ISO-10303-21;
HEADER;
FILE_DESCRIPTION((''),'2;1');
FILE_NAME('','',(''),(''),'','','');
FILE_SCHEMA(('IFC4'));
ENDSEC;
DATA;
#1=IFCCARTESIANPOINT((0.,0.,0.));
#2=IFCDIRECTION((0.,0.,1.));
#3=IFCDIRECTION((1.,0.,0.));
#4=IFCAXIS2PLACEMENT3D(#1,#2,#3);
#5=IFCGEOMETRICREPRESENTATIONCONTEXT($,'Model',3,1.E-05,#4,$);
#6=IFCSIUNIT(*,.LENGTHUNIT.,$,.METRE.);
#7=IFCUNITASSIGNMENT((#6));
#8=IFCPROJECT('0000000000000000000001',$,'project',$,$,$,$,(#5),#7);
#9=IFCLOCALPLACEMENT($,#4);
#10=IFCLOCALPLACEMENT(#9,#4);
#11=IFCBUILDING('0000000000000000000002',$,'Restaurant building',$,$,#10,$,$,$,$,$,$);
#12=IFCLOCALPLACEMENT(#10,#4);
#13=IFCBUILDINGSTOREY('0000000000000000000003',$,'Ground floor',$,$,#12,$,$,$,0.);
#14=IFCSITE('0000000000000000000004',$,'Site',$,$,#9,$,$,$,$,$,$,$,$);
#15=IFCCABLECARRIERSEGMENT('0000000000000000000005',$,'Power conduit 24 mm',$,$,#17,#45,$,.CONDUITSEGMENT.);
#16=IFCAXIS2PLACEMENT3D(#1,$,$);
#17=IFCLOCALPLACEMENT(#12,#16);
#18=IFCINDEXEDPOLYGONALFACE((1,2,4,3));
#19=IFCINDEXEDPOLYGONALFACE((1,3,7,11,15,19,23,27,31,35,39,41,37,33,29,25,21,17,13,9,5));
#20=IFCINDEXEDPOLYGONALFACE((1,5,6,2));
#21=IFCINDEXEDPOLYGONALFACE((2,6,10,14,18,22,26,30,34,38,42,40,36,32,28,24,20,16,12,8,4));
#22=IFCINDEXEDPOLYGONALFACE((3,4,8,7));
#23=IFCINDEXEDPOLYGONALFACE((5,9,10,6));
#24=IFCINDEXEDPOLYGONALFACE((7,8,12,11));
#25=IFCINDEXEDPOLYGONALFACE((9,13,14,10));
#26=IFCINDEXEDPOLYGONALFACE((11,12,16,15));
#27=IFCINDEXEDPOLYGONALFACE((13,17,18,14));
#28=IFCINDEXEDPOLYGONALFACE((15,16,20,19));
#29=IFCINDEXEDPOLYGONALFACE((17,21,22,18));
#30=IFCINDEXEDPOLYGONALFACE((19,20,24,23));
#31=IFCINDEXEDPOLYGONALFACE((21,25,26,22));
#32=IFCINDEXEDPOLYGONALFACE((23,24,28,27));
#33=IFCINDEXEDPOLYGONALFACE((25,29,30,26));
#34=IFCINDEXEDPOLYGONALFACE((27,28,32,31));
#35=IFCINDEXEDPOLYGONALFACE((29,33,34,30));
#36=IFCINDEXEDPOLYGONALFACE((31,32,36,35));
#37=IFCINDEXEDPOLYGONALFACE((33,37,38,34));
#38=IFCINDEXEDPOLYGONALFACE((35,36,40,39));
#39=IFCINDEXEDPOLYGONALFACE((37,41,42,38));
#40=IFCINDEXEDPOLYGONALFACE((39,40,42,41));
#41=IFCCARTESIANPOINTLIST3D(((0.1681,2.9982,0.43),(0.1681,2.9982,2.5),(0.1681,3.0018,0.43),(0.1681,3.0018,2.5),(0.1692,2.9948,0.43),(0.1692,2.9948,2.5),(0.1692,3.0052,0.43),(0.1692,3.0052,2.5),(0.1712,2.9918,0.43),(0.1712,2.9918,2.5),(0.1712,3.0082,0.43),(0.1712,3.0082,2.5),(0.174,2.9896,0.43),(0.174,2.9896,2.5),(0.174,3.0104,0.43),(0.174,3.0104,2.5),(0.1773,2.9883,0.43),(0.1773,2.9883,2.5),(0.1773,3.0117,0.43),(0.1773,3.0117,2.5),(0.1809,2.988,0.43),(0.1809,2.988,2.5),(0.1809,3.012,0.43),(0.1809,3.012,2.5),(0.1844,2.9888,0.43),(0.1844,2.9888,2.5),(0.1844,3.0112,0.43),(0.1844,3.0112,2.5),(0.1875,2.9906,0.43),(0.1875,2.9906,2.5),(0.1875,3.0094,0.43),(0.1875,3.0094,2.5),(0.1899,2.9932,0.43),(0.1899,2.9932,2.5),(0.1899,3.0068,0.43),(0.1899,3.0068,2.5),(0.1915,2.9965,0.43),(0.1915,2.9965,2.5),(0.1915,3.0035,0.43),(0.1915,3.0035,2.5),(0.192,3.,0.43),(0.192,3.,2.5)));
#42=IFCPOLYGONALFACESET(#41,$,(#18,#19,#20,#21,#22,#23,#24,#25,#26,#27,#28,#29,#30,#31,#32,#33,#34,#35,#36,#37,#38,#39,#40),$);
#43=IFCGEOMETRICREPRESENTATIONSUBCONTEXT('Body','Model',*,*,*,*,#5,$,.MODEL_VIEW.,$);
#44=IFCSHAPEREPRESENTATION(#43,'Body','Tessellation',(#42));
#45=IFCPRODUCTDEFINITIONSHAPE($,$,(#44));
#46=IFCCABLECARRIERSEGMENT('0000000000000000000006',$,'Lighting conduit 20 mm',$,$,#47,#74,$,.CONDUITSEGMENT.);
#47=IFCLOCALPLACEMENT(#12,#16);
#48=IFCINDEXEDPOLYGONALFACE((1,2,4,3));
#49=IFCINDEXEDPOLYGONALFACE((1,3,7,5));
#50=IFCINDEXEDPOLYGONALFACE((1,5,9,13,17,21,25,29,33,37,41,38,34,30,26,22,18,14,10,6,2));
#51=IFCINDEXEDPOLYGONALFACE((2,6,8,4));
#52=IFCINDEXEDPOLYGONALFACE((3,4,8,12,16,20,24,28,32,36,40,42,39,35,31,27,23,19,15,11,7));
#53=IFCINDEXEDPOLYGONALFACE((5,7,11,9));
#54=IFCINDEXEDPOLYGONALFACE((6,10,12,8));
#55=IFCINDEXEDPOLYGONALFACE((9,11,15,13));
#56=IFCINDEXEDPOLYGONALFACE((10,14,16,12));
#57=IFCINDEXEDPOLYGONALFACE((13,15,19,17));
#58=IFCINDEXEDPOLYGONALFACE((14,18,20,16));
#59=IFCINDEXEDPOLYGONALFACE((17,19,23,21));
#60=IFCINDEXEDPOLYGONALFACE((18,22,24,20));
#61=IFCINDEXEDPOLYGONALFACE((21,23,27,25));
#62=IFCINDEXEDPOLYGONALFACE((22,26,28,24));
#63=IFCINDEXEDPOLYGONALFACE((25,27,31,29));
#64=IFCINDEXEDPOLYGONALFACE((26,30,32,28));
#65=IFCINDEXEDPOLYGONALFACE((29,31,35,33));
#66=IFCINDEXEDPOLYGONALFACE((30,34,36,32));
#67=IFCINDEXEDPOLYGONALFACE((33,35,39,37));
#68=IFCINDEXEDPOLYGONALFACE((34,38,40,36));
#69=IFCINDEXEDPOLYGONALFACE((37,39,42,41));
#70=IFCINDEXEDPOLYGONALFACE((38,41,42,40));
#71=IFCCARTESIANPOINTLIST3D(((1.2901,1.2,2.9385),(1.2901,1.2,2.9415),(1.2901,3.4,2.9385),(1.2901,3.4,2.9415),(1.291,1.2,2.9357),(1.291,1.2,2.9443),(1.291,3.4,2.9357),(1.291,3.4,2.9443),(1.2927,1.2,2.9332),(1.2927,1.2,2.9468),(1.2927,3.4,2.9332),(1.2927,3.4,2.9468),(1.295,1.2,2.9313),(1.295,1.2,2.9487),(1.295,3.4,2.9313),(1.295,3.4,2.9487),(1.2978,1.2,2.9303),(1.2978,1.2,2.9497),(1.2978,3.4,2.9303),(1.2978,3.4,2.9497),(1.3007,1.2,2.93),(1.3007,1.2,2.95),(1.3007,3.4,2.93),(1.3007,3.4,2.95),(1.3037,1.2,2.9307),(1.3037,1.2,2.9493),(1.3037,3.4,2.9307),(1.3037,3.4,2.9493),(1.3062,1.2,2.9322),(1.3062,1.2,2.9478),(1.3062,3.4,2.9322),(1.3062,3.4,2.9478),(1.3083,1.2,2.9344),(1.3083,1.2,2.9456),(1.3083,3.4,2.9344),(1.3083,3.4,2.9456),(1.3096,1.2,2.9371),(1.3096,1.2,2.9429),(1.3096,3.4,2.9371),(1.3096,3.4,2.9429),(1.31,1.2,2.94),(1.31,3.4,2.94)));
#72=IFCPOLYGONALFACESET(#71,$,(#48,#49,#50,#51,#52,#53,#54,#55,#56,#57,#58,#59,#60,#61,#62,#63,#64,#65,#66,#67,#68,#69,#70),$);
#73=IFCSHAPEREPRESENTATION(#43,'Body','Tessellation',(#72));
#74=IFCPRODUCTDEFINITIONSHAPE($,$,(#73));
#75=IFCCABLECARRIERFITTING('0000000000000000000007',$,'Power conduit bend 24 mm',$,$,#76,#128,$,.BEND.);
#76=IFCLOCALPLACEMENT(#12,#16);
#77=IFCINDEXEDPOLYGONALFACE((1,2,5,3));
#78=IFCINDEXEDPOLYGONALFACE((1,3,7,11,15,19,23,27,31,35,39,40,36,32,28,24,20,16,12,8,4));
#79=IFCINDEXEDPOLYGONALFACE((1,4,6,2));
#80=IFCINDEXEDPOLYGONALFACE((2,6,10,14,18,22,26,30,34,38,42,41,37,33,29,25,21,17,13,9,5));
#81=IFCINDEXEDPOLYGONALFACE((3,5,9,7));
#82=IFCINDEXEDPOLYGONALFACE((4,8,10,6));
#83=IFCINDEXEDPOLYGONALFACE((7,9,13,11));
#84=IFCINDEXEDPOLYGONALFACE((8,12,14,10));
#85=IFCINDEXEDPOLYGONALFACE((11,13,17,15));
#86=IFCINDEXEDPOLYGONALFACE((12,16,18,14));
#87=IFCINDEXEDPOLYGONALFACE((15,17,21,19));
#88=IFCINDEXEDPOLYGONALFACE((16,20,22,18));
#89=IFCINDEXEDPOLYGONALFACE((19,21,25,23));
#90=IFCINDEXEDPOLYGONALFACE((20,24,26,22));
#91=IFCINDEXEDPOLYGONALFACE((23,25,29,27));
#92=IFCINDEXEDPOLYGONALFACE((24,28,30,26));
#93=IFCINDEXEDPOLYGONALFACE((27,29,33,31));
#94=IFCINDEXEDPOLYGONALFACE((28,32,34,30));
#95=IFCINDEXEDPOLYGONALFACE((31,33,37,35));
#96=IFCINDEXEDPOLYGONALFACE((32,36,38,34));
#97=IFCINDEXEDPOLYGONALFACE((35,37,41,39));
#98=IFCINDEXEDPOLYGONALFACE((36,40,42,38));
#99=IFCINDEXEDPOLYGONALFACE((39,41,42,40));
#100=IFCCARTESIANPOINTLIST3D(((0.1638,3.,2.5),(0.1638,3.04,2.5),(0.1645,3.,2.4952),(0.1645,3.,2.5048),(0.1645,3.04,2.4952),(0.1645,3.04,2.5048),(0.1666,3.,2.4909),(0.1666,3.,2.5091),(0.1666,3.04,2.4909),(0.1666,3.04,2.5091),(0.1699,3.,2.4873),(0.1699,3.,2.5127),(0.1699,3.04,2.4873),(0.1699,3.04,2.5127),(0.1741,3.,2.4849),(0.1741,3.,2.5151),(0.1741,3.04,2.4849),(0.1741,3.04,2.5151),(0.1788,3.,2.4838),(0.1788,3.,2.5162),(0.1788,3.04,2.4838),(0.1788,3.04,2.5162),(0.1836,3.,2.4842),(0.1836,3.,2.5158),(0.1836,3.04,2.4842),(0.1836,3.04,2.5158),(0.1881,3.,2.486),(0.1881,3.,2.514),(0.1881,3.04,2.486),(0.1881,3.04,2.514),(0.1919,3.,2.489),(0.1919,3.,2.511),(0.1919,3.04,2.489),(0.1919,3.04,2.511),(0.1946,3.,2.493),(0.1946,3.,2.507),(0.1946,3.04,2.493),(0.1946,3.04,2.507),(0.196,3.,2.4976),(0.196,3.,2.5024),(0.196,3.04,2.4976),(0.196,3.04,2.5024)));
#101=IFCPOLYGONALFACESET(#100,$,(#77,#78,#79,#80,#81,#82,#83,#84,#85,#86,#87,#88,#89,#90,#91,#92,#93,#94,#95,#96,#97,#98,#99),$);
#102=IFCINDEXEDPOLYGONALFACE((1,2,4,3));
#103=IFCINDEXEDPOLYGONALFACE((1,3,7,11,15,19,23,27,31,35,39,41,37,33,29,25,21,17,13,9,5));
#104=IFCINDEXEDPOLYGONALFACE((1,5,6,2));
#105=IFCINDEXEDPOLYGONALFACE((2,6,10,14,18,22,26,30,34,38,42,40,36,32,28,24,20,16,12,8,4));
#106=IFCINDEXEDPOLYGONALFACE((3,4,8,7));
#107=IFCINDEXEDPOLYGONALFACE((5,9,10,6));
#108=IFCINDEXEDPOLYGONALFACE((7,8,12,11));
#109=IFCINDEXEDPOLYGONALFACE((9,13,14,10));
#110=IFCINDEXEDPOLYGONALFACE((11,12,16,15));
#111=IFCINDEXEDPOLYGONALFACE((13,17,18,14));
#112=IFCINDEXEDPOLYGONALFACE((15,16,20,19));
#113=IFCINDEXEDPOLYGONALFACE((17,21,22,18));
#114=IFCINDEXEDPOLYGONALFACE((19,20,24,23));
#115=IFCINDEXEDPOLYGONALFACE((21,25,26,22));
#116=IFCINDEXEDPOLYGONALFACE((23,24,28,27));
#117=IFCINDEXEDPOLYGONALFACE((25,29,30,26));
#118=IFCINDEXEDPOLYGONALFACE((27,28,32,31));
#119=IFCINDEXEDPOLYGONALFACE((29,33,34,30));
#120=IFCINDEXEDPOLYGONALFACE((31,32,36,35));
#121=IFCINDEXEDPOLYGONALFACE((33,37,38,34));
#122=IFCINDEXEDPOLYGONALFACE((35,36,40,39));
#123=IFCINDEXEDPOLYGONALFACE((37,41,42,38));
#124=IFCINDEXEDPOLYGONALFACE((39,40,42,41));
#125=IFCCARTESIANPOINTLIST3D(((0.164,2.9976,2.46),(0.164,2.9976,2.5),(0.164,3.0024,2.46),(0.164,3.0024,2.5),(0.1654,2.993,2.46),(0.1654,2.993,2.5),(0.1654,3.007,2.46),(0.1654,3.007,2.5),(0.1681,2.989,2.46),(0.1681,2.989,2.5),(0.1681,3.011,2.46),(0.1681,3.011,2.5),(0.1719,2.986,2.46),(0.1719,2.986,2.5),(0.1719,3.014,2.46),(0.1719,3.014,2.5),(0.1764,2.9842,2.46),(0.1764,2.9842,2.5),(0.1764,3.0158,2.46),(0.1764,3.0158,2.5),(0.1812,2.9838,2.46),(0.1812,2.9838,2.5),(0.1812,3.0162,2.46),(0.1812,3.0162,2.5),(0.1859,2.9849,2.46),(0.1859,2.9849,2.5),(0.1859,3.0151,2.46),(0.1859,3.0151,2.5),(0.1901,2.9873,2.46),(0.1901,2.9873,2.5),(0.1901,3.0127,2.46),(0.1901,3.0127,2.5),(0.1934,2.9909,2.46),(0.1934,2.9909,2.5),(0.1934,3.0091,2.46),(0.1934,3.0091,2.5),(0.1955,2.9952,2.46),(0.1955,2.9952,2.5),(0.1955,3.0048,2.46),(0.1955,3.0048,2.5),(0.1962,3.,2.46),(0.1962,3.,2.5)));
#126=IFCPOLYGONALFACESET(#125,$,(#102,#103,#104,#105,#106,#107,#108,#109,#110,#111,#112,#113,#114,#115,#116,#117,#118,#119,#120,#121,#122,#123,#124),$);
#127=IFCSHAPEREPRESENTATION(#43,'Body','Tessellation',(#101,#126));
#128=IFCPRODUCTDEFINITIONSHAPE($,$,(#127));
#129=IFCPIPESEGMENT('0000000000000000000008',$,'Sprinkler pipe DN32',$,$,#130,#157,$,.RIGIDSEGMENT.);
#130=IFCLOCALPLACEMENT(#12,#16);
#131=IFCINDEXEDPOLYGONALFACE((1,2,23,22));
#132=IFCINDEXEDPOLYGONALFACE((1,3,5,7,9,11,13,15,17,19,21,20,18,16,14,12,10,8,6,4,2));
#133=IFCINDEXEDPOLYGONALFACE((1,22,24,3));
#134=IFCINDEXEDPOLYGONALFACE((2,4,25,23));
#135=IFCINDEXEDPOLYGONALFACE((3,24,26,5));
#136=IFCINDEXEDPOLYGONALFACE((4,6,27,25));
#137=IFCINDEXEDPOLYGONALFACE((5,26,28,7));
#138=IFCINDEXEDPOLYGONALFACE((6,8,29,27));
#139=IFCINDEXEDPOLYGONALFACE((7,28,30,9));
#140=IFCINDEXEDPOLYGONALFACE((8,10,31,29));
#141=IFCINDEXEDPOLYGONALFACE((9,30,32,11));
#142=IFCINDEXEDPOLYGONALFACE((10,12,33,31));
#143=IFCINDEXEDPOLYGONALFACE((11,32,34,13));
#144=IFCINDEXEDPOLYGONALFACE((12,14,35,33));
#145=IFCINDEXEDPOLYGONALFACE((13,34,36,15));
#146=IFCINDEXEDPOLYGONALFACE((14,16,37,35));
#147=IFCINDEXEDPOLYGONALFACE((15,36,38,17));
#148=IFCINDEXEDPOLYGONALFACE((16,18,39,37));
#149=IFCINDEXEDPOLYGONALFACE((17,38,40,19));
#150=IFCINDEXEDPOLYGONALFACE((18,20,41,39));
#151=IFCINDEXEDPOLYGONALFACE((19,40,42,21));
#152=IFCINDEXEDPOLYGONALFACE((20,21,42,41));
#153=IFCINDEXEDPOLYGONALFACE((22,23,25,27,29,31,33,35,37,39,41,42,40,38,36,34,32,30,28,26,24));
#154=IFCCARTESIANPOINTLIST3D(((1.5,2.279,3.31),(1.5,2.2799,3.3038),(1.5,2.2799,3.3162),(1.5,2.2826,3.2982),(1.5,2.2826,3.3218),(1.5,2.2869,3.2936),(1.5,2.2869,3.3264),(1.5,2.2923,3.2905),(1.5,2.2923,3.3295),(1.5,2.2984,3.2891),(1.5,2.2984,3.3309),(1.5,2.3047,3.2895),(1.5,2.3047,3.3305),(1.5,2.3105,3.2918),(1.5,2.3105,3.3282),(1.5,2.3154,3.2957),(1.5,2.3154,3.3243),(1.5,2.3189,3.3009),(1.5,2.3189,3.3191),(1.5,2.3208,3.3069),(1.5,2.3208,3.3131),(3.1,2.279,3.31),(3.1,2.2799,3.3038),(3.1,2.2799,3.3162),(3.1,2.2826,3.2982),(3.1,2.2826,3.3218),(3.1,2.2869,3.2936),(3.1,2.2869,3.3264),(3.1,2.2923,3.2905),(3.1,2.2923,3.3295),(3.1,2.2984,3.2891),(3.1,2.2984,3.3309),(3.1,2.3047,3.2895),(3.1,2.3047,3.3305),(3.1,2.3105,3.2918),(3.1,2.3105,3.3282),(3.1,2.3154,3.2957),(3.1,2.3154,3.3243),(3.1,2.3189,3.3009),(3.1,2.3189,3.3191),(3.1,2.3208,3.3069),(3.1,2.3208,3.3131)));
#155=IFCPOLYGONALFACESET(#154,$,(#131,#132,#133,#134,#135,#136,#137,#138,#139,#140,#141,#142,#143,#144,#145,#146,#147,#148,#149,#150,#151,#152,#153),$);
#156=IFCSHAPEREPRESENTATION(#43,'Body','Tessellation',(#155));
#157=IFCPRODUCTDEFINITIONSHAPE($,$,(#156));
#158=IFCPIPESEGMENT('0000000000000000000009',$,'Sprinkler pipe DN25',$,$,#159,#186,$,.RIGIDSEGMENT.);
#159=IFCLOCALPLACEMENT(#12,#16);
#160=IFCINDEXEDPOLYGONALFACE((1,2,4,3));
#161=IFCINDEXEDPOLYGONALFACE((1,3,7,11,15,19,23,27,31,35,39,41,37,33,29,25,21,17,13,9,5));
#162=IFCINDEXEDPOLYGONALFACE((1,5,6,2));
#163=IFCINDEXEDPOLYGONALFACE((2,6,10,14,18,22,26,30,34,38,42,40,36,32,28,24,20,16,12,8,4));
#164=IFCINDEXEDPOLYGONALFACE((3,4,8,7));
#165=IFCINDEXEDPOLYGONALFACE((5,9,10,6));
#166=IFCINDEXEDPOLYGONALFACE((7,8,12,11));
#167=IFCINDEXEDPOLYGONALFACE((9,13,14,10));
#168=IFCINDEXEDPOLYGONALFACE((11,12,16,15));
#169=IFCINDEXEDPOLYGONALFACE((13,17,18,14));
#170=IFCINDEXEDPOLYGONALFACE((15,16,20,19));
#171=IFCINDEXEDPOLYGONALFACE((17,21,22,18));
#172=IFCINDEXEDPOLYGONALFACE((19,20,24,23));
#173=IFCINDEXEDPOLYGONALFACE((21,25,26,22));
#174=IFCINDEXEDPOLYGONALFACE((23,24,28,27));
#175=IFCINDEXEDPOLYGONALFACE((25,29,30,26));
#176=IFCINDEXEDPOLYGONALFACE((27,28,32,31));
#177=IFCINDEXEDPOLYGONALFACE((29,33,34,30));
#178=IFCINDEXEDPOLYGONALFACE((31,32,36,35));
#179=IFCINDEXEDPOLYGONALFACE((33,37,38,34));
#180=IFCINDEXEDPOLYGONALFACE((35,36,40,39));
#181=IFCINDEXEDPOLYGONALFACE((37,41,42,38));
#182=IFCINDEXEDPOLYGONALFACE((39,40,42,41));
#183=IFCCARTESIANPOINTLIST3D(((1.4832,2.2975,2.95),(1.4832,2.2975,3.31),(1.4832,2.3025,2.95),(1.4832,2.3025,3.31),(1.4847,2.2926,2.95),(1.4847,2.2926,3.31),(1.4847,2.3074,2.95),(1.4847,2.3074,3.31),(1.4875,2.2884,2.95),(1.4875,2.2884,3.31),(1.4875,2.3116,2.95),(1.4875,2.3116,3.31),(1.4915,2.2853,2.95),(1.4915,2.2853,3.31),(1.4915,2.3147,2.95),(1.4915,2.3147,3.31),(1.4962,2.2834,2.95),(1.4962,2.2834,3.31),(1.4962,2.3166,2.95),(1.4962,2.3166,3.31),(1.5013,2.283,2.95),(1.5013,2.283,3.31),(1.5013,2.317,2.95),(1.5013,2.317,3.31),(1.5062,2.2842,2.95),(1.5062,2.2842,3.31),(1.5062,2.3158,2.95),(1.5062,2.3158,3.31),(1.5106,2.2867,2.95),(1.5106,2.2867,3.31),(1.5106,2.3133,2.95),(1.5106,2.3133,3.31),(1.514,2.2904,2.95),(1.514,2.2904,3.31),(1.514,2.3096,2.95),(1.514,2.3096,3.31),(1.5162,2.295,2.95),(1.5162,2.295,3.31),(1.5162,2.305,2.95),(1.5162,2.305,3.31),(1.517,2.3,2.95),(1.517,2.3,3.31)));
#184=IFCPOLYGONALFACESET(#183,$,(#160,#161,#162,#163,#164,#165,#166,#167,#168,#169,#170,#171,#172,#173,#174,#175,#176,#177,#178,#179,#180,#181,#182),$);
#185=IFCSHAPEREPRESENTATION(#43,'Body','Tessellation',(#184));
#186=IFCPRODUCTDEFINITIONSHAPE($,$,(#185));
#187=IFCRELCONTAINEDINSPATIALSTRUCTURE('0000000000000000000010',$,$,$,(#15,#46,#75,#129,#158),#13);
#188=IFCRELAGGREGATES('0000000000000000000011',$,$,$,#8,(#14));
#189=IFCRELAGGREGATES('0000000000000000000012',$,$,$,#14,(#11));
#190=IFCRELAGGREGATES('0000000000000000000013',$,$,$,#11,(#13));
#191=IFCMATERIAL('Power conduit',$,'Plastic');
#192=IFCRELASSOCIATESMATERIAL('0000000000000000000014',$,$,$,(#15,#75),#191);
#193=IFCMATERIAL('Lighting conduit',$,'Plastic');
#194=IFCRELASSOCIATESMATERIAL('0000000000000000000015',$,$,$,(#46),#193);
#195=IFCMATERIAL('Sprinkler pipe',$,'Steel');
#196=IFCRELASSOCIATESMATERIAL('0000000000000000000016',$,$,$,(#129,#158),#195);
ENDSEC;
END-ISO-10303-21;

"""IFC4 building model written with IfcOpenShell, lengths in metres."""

from ifc_helpers import new_model, si_unit, frame, origin_with_axes, origin_2d, place, context, subcontext, project, spatial, circle, extrude, material, element, save


model = new_model("IFC4")

# Units and contexts
model_context = context("Model", 3, precision=1e-05, world=origin_with_axes())
body_context = subcontext(model_context, "Body", "Model", "MODEL_VIEW")
ifc_project = project(units=[si_unit("LENGTHUNIT", "METRE")], contexts=[model_context])

# Site, building, storey
site_placement = place(None, origin_with_axes())
site = spatial("IfcSite", under=ifc_project, at=site_placement, Name="Site")
building_placement = place(site_placement, origin_with_axes())
building = spatial("IfcBuilding", under=site, at=building_placement, Name="Restaurant building")
storey_placement = place(building_placement, origin_with_axes())
storey = spatial("IfcBuildingStorey", under=building, at=storey_placement, Name="Ground floor", Elevation=0.0)

# Cable carrier segments
ifc_material_1 = material(Name="Power conduit", Category="Plastic")
cable_carrier_segment_1_placement = place(storey_placement, frame((0.18, 3.0, 2.5)))
element("IfcCableCarrierSegment", 1, at=cable_carrier_segment_1_placement, inside=storey, material=ifc_material_1, Name="Power conduit 24 mm", PredefinedType="CONDUITSEGMENT", context=body_context, shape_type="SweptSolid", body=[
    extrude(circle(Radius=0.012, at=origin_2d()), frame((0.0, 0.0, 0.0), z_axis=(0.0, 0.0, -1.0), x_axis=(1.0, 0.0, 0.0)), (0.0, 0.0, 1.0), 2.07),
])
ifc_material_2 = material(Name="Lighting conduit", Category="Plastic")
cable_carrier_segment_2_placement = place(storey_placement, frame((1.3, 3.4, 2.94)))
element("IfcCableCarrierSegment", 2, at=cable_carrier_segment_2_placement, inside=storey, material=ifc_material_2, Name="Lighting conduit 20 mm", PredefinedType="CONDUITSEGMENT", context=body_context, shape_type="SweptSolid", body=[
    extrude(circle(Radius=0.01, at=origin_2d()), frame((0.0, 0.0, 0.0), z_axis=(0.0, -1.0, 0.0), x_axis=(1.0, 0.0, 0.0)), (0.0, 0.0, 1.0), 2.2),
])

# Cable carrier fitting
cable_carrier_fitting_placement = place(storey_placement, frame((0.18, 3.0, 2.5)))
element("IfcCableCarrierFitting", 3, at=cable_carrier_fitting_placement, inside=storey, material=ifc_material_1, Name="Power conduit bend 24 mm", PredefinedType="BEND", context=body_context, shape_type="SweptSolid", body=[
    extrude(circle(Radius=0.0162, at=origin_2d()), frame((0.0, 0.0, 0.0), z_axis=(0.0, 1.0, 0.0), x_axis=(-1.0, 0.0, 0.0)), (0.0, 0.0, 1.0), 0.04),
    extrude(circle(Radius=0.0162, at=origin_2d()), frame((0.0, 0.0, 0.0), z_axis=(0.0, 0.0, -1.0), x_axis=(1.0, 0.0, 0.0)), (0.0, 0.0, 1.0), 0.04),
])

# Pipe segments
ifc_material_3 = material(Name="Sprinkler pipe", Category="Steel")
pipe_segment_placement = place(storey_placement, frame((3.1, 2.3, 3.31)))
element("IfcPipeSegment", 4, at=pipe_segment_placement, inside=storey, material=ifc_material_3, Name="Sprinkler pipe DN32", PredefinedType="RIGIDSEGMENT", context=body_context, shape_type="SweptSolid", body=[
    extrude(circle(Radius=0.021, at=origin_2d()), frame((0.0, 0.0, 0.0), z_axis=(-1.0, 0.0, 0.0), x_axis=(0.0, -1.0, 0.0)), (0.0, 0.0, 1.0), 1.6),
])
for number, where, name in (
    (5, (1.5, 2.3, 3.31), "Sprinkler pipe DN25"),
):
    element("IfcPipeSegment", number, at=place(storey_placement, frame(where)), inside=storey, material=ifc_material_3, Name=name, PredefinedType="RIGIDSEGMENT", context=body_context, shape_type="SweptSolid", body=[
        extrude(circle(Radius=0.017, at=origin_2d()), frame((0.0, 0.0, 0.0), z_axis=(0.0, 0.0, -1.0), x_axis=(1.0, 0.0, 0.0)), (0.0, 0.0, 1.0), 0.36),
    ])

save(model, "model.ifc")
